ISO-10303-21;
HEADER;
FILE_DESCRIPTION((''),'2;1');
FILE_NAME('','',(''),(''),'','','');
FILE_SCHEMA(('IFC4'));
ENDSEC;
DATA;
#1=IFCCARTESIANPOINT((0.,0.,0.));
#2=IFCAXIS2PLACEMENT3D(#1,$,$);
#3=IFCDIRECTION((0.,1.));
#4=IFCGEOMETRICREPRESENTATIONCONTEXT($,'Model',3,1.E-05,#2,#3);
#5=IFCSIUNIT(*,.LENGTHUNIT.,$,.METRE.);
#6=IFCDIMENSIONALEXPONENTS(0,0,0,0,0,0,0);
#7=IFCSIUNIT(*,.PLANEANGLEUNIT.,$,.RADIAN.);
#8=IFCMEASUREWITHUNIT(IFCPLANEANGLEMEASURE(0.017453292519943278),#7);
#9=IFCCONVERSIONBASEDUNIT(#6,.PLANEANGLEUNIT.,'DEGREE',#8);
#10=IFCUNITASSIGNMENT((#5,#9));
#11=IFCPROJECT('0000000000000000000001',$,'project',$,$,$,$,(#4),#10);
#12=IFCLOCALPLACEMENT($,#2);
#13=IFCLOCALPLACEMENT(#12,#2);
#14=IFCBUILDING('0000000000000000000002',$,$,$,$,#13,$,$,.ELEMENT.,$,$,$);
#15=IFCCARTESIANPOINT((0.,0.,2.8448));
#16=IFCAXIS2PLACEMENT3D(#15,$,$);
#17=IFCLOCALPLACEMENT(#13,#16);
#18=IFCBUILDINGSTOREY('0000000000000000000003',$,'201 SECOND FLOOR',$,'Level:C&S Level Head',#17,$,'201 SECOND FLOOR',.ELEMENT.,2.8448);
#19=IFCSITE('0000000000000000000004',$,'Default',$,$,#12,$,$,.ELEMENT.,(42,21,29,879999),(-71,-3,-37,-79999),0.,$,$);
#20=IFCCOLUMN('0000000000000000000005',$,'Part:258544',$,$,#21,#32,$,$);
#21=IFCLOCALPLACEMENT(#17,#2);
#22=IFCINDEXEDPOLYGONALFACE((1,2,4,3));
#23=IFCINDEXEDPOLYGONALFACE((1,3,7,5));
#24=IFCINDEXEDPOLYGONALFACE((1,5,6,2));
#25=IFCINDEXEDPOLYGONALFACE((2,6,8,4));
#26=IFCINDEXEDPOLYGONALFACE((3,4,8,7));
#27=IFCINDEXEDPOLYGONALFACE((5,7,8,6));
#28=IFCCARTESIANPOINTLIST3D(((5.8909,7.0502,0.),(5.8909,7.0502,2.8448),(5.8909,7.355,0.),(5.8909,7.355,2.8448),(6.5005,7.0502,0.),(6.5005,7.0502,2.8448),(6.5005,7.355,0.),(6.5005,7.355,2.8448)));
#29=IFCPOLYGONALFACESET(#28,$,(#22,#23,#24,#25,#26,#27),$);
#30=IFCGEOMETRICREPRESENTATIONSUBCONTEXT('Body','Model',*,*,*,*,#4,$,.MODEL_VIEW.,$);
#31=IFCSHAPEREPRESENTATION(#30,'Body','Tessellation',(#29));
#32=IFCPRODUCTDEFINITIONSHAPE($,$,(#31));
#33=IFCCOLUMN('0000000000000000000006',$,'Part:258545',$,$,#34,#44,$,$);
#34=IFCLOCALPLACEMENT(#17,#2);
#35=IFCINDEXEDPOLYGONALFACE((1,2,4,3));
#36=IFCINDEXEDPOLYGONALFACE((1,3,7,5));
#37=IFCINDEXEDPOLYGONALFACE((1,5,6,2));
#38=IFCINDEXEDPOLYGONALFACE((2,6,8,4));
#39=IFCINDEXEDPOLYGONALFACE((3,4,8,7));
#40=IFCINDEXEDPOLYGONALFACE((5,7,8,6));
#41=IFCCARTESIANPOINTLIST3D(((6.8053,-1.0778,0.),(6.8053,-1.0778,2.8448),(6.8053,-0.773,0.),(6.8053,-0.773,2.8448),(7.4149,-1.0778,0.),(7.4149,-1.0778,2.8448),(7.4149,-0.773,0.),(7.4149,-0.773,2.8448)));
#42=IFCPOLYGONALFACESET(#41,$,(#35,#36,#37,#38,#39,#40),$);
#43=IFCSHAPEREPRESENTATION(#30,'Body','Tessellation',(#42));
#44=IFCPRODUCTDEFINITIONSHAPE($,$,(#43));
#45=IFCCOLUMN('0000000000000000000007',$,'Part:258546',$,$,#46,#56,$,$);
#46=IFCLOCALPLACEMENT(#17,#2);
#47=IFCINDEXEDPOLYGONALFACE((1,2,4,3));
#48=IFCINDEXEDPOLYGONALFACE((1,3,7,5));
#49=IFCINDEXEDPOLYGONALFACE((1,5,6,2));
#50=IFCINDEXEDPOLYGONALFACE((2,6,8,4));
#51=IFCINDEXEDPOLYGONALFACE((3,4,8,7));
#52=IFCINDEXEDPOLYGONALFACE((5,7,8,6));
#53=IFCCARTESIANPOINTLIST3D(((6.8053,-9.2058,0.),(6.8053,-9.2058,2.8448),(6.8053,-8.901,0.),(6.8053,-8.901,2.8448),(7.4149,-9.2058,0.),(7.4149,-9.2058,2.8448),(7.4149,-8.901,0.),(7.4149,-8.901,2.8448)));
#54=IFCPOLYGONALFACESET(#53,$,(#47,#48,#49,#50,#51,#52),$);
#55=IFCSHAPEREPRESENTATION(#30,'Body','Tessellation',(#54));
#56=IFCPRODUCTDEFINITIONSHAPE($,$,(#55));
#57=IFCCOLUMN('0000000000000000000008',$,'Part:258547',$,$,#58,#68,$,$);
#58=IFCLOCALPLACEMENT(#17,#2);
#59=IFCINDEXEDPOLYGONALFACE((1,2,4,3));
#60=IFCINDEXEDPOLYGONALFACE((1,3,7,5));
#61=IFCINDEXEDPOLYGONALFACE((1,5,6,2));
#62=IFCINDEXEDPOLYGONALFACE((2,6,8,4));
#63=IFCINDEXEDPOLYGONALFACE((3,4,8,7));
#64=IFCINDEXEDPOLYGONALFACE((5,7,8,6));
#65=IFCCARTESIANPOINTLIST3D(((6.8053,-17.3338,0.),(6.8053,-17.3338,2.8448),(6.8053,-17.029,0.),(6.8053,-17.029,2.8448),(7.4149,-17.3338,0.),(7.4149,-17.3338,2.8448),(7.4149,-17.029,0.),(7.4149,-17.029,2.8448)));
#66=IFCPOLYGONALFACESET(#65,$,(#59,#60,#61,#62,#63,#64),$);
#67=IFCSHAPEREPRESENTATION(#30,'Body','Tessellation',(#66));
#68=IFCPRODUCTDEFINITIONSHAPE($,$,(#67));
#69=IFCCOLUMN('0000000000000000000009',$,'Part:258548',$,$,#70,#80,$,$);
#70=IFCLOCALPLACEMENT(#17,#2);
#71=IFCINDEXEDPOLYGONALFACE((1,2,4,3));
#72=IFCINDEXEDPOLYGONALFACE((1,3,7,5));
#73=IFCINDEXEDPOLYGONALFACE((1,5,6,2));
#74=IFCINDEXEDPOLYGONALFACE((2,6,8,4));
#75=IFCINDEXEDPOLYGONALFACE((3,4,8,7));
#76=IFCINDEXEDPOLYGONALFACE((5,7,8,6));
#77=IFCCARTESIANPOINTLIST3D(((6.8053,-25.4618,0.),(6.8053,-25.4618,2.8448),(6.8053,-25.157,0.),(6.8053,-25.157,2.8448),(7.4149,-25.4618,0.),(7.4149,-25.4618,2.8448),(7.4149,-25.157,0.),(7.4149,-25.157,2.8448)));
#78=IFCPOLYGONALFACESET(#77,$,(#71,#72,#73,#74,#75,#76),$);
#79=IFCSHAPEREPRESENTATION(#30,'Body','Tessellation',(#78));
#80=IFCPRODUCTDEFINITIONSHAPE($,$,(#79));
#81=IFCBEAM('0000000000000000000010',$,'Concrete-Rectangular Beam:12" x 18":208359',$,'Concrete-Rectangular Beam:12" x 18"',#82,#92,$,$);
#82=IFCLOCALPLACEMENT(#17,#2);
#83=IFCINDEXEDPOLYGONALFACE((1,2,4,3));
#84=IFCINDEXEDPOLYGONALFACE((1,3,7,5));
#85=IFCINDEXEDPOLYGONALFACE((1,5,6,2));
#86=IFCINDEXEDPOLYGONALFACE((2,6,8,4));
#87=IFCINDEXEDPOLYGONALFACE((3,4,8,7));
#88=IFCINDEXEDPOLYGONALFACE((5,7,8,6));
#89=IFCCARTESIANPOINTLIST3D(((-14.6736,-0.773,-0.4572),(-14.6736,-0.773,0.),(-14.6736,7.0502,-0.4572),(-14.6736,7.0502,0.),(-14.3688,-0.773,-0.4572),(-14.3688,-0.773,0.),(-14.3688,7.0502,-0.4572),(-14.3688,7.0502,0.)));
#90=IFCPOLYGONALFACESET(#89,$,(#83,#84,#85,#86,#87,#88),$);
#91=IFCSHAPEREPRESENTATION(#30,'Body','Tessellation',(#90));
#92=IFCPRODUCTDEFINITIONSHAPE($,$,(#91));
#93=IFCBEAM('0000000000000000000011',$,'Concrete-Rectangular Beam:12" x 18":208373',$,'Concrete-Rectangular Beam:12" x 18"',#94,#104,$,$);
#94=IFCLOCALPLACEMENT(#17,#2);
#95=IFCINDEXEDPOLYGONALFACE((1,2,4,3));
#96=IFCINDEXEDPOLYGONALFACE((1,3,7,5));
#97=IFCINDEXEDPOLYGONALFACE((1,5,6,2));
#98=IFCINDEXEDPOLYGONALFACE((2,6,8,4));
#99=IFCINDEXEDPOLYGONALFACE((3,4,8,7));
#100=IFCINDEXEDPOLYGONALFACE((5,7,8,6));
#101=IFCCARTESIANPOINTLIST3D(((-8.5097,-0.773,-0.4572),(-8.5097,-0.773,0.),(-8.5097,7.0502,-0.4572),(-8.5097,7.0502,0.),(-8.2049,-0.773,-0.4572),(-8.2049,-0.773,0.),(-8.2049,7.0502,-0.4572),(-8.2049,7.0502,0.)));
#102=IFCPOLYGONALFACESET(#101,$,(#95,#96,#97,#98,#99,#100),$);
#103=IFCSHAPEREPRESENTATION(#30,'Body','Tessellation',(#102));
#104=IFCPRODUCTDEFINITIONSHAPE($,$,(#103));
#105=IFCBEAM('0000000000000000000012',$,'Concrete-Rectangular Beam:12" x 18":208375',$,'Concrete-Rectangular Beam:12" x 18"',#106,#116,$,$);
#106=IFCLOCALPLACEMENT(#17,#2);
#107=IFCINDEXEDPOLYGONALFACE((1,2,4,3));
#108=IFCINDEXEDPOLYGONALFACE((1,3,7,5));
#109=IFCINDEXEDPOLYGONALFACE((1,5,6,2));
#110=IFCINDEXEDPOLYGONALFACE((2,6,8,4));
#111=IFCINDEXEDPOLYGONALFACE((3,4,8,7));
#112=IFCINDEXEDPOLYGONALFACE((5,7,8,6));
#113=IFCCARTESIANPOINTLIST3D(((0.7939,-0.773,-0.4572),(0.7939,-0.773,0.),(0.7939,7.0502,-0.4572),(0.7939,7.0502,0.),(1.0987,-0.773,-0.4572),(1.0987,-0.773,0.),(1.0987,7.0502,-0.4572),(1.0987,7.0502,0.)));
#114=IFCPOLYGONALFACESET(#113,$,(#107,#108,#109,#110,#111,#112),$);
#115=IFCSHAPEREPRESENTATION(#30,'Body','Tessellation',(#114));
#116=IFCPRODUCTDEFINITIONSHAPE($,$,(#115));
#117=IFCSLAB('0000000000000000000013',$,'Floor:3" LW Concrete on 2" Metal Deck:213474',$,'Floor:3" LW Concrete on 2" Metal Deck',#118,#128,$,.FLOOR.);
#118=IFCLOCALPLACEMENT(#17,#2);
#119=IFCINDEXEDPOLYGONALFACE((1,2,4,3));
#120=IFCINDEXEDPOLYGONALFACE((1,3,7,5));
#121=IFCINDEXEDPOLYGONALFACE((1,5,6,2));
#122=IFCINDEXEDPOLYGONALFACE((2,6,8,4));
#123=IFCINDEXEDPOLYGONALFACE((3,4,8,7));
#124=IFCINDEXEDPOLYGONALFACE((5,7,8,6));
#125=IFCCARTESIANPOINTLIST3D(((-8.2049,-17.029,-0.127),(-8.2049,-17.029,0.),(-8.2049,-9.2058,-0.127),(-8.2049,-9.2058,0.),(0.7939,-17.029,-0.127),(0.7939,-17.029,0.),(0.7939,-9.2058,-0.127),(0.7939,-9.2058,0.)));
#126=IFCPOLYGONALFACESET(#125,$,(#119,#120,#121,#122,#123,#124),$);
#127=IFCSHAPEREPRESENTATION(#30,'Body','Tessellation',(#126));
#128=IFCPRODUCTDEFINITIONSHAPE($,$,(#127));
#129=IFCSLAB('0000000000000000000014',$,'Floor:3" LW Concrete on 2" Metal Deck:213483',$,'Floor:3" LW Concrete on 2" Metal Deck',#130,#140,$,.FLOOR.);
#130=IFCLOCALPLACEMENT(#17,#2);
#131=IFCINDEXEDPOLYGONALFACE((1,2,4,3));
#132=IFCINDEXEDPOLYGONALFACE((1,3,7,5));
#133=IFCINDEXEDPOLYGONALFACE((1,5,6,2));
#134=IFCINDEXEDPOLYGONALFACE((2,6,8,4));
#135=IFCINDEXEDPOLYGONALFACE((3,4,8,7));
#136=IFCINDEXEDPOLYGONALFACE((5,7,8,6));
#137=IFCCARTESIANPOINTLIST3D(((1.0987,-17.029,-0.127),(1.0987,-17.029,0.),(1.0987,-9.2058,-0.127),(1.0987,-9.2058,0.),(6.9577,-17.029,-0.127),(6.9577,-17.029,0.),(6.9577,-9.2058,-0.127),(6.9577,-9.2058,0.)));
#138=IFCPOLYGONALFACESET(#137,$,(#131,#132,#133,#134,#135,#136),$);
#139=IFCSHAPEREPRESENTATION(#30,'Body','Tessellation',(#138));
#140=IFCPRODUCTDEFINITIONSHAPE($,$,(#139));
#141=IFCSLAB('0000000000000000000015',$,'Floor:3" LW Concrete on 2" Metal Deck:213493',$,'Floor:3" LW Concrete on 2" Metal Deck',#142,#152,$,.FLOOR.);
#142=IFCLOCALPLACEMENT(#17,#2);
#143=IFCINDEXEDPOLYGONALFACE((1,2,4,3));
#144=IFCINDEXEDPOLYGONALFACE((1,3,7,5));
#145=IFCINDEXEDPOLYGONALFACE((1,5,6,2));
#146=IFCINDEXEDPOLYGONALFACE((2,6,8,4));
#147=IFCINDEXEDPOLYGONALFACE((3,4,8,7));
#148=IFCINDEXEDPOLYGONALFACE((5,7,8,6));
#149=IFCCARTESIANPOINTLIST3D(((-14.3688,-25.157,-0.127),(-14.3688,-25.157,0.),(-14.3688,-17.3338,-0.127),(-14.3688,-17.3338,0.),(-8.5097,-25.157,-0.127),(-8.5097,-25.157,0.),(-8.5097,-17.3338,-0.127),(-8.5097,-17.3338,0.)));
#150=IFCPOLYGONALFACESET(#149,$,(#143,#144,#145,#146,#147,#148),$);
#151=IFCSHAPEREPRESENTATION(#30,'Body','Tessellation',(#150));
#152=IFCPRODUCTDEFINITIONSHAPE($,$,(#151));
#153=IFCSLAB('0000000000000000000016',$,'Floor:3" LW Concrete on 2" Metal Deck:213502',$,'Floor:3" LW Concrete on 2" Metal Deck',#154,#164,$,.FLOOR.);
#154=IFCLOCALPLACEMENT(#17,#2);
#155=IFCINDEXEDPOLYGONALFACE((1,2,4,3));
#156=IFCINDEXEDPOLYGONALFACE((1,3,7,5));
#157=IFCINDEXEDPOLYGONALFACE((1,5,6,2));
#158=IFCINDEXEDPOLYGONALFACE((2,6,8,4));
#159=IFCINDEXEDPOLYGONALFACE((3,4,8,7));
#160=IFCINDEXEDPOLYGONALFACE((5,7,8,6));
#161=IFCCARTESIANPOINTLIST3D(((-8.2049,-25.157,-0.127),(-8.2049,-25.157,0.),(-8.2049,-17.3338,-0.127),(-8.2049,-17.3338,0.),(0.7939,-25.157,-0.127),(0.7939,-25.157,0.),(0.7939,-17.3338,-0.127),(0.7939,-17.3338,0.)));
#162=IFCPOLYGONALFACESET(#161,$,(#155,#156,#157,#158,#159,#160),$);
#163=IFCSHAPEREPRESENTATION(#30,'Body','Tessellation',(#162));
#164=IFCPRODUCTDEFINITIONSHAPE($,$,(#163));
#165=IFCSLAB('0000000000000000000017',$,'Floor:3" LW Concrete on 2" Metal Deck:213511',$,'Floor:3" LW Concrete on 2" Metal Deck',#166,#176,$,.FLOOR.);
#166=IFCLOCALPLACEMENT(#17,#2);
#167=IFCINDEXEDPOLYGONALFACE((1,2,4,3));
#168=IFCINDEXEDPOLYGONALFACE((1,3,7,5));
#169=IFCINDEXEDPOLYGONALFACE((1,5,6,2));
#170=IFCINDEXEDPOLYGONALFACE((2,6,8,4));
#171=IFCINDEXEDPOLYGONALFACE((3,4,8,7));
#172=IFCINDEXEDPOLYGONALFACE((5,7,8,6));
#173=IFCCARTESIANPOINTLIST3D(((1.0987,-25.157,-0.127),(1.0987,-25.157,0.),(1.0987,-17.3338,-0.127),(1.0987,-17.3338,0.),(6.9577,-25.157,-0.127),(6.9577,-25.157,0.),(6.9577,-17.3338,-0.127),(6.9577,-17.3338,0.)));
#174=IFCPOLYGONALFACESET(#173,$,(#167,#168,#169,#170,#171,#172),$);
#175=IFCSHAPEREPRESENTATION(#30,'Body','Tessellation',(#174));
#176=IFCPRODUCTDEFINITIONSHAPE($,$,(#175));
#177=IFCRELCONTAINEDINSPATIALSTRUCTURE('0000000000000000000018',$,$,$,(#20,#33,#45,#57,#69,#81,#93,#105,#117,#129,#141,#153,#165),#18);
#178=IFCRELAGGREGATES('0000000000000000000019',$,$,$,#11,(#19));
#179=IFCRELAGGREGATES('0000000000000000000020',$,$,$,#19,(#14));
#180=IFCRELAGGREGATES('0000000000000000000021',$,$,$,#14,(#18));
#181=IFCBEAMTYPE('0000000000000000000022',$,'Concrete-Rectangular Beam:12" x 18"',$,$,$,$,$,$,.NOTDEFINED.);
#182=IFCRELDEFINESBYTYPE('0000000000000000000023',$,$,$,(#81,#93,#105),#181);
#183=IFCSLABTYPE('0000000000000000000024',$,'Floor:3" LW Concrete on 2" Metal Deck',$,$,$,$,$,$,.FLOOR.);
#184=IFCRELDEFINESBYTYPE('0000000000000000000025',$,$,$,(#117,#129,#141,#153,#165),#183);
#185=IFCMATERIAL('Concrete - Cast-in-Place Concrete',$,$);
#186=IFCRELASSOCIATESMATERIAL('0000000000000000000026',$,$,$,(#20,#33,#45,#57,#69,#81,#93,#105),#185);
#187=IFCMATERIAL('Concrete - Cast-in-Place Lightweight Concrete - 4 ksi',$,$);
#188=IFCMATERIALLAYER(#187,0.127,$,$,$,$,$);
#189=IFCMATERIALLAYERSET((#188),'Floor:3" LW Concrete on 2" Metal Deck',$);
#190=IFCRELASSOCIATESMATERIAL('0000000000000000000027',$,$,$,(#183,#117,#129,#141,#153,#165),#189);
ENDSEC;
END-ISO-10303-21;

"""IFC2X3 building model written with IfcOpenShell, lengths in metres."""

from ifc_helpers import new_model, entity, si_unit, converted_unit, direction, frame, frame_2d, origin, origin_2d_with_axis, place, context, subcontext, project, spatial, rectangle, extrude, material, layer, layer_set, layer_usage, type_object, element, save


model = new_model("IFC2X3")

# Units and contexts
model_context = context("Model", 3, precision=1e-05, world=origin(), true_north=direction((0.0, 1.0)))
body_context = subcontext(model_context, "Body", "Model", "MODEL_VIEW")
ifc_project = project(units=[si_unit("LENGTHUNIT", "METRE"), converted_unit("PLANEANGLEUNIT", "DEGREE", entity("IfcPlaneAngleMeasure", 0.017453292519943278), si_unit("PLANEANGLEUNIT", "RADIAN"), dimensions=[0, 0, 0, 0, 0, 0, 0])], contexts=[model_context])

# Site, building, storey
site_placement = place(None, origin())
site = spatial("IfcSite", under=ifc_project, at=site_placement, Name="Default", CompositionType="ELEMENT", RefLatitude=(42, 21, 29, 879999), RefLongitude=(-71, -3, -37, -79999), RefElevation=0.0)
building_placement = place(site_placement, origin())
building = spatial("IfcBuilding", under=site, at=building_placement, CompositionType="ELEMENT")
storey_placement = place(building_placement, frame((0.0, 0.0, 2.8448)))
storey = spatial("IfcBuildingStorey", under=building, at=storey_placement, Name="201 SECOND FLOOR", ObjectType="Level:C&S Level Head", LongName="201 SECOND FLOOR", CompositionType="ELEMENT", Elevation=2.8448)

# Columns
ifc_material_1 = material(Name="Concrete - Cast-in-Place Concrete")
column_1_placement = place(storey_placement, origin())
element("IfcColumn", 1, at=column_1_placement, inside=storey, material=ifc_material_1, Name="Part:258544", context=body_context, shape_type="SweptSolid", body=[
    extrude(rectangle(XDim=2.8448, YDim=0.3048, at=frame_2d((0.0, 0.0), x_axis=(1.0, 0.0))), frame((5.8909, 7.2026, 1.4224), z_axis=(1.0, 0.0, 0.0), x_axis=(0.0, 0.0, -1.0)), (0.0, 0.0, 1.0), 0.6096),
])
column_2_placement = place(storey_placement, origin())
element("IfcColumn", 2, at=column_2_placement, inside=storey, material=ifc_material_1, Name="Part:258545", context=body_context, shape_type="SweptSolid", body=[
    extrude(rectangle(XDim=2.8448, YDim=0.3048, at=frame_2d((0.0, 0.0), x_axis=(1.0, 0.0))), frame((6.8053, -0.9254, 1.4224), z_axis=(1.0, 0.0, 0.0), x_axis=(0.0, 0.0, -1.0)), (0.0, 0.0, 1.0), 0.6096),
])
column_3_placement = place(storey_placement, origin())
element("IfcColumn", 3, at=column_3_placement, inside=storey, material=ifc_material_1, Name="Part:258546", context=body_context, shape_type="SweptSolid", body=[
    extrude(rectangle(XDim=2.8448, YDim=0.3048, at=frame_2d((0.0, 0.0), x_axis=(1.0, 0.0))), frame((6.8053, -9.0534, 1.4224), z_axis=(1.0, 0.0, 0.0), x_axis=(0.0, 0.0, -1.0)), (0.0, 0.0, 1.0), 0.6096),
])
column_4_placement = place(storey_placement, origin())
element("IfcColumn", 4, at=column_4_placement, inside=storey, material=ifc_material_1, Name="Part:258547", context=body_context, shape_type="SweptSolid", body=[
    extrude(rectangle(XDim=2.8448, YDim=0.3048, at=frame_2d((0.0, 0.0), x_axis=(1.0, 0.0))), frame((6.8053, -17.1814, 1.4224), z_axis=(1.0, 0.0, 0.0), x_axis=(0.0, 0.0, -1.0)), (0.0, 0.0, 1.0), 0.6096),
])
column_5_placement = place(storey_placement, origin())
element("IfcColumn", 5, at=column_5_placement, inside=storey, material=ifc_material_1, Name="Part:258548", context=body_context, shape_type="SweptSolid", body=[
    extrude(rectangle(XDim=2.8448, YDim=0.3048, at=frame_2d((0.0, 0.0), x_axis=(1.0, 0.0))), frame((6.8053, -25.3094, 1.4224), z_axis=(1.0, 0.0, 0.0), x_axis=(0.0, 0.0, -1.0)), (0.0, 0.0, 1.0), 0.6096),
])

# Beams
beam_type = type_object("IfcBeamType", Name="Concrete-Rectangular Beam:12\" x 18\"", PredefinedType="NOTDEFINED")
beam_1_placement = place(storey_placement, frame((-14.5212, 7.0502, 0.0), z_axis=(0.0, 0.0, 1.0), x_axis=(0.0, -1.0, 0.0)))
element("IfcBeam", 6, at=beam_1_placement, inside=storey, type_object=beam_type, material=ifc_material_1, Name="Concrete-Rectangular Beam:12\" x 18\":208359", ObjectType="Concrete-Rectangular Beam:12\" x 18\"", context=body_context, shape_type="SweptSolid", body=[
    extrude(rectangle(XDim=0.4572, YDim=0.3048, at=origin_2d_with_axis()), frame((0.0, 0.0, -0.2286), z_axis=(1.0, 0.0, 0.0), x_axis=(0.0, 0.0, -1.0)), (0.0, 0.0, 1.0), 7.8232),
])
beam_2_placement = place(storey_placement, frame((-8.3573, 7.0502, 0.0), z_axis=(0.0, 0.0, 1.0), x_axis=(0.0, -1.0, 0.0)))
element("IfcBeam", 7, at=beam_2_placement, inside=storey, type_object=beam_type, material=ifc_material_1, Name="Concrete-Rectangular Beam:12\" x 18\":208373", ObjectType="Concrete-Rectangular Beam:12\" x 18\"", context=body_context, shape_type="SweptSolid", body=[
    extrude(rectangle(XDim=0.4572, YDim=0.3048, at=frame_2d((0.0, 0.0), x_axis=(1.0, 0.0))), frame((0.0, 0.0, -0.2286), z_axis=(1.0, 0.0, 0.0), x_axis=(0.0, 0.0, -1.0)), (0.0, 0.0, 1.0), 7.8232),
])
beam_3_placement = place(storey_placement, frame((0.9463, 7.0502, 0.0), z_axis=(0.0, 0.0, 1.0), x_axis=(0.0, -1.0, 0.0)))
element("IfcBeam", 8, at=beam_3_placement, inside=storey, type_object=beam_type, material=ifc_material_1, Name="Concrete-Rectangular Beam:12\" x 18\":208375", ObjectType="Concrete-Rectangular Beam:12\" x 18\"", context=body_context, shape_type="SweptSolid", body=[
    extrude(rectangle(XDim=0.4572, YDim=0.3048, at=origin_2d_with_axis()), frame((0.0, 0.0, -0.2286), z_axis=(1.0, 0.0, 0.0), x_axis=(0.0, 0.0, -1.0)), (0.0, 0.0, 1.0), 7.8232),
])

# Slabs
ifc_material_2 = material(Name="Concrete - Cast-in-Place Lightweight Concrete - 4 ksi")
ifc_layer = layer(ifc_material_2, 0.127)
ifc_layer_set = layer_set([ifc_layer], Name="Floor:3\" LW Concrete on 2\" Metal Deck")
ifc_layer_usage_1 = layer_usage(ifc_layer_set, "AXIS3", "POSITIVE", 0.0)
slab_type = type_object("IfcSlabType", Name="Floor:3\" LW Concrete on 2\" Metal Deck", PredefinedType="FLOOR", material=ifc_layer_set)
slab_1_placement = place(storey_placement, origin())
element("IfcSlab", 9, at=slab_1_placement, inside=storey, type_object=slab_type, material=ifc_layer_usage_1, Name="Floor:3\" LW Concrete on 2\" Metal Deck:213474", ObjectType="Floor:3\" LW Concrete on 2\" Metal Deck", PredefinedType="FLOOR", context=body_context, shape_type="SweptSolid", body=[
    extrude(rectangle(XDim=7.8232, YDim=8.9988, at=frame_2d((0.0, 0.0), x_axis=(1.0, 0.0))), frame((-3.7055, -13.1174, 0.0), z_axis=(0.0, 0.0, -1.0), x_axis=(0.0, 1.0, 0.0)), (0.0, 0.0, 1.0), 0.127),
])
ifc_layer_usage_2 = layer_usage(ifc_layer_set, "AXIS3", "POSITIVE", 0.0)
slab_2_placement = place(storey_placement, origin())
element("IfcSlab", 10, at=slab_2_placement, inside=storey, type_object=slab_type, material=ifc_layer_usage_2, Name="Floor:3\" LW Concrete on 2\" Metal Deck:213483", ObjectType="Floor:3\" LW Concrete on 2\" Metal Deck", PredefinedType="FLOOR", context=body_context, shape_type="SweptSolid", body=[
    extrude(rectangle(XDim=7.8232, YDim=5.859, at=frame_2d((0.0, 0.0), x_axis=(1.0, 0.0))), frame((4.0282, -13.1174, 0.0), z_axis=(0.0, 0.0, -1.0), x_axis=(0.0, 1.0, 0.0)), (0.0, 0.0, 1.0), 0.127),
])
ifc_layer_usage_3 = layer_usage(ifc_layer_set, "AXIS3", "POSITIVE", 0.0)
slab_3_placement = place(storey_placement, origin())
element("IfcSlab", 11, at=slab_3_placement, inside=storey, type_object=slab_type, material=ifc_layer_usage_3, Name="Floor:3\" LW Concrete on 2\" Metal Deck:213493", ObjectType="Floor:3\" LW Concrete on 2\" Metal Deck", PredefinedType="FLOOR", context=body_context, shape_type="SweptSolid", body=[
    extrude(rectangle(XDim=7.8232, YDim=5.859, at=frame_2d((0.0, 0.0), x_axis=(1.0, 0.0))), frame((-11.4393, -21.2454, 0.0), z_axis=(0.0, 0.0, -1.0), x_axis=(0.0, 1.0, 0.0)), (0.0, 0.0, 1.0), 0.127),
])
ifc_layer_usage_4 = layer_usage(ifc_layer_set, "AXIS3", "POSITIVE", 0.0)
slab_4_placement = place(storey_placement, origin())
element("IfcSlab", 12, at=slab_4_placement, inside=storey, type_object=slab_type, material=ifc_layer_usage_4, Name="Floor:3\" LW Concrete on 2\" Metal Deck:213502", ObjectType="Floor:3\" LW Concrete on 2\" Metal Deck", PredefinedType="FLOOR", context=body_context, shape_type="SweptSolid", body=[
    extrude(rectangle(XDim=7.8232, YDim=8.9988, at=frame_2d((0.0, 0.0), x_axis=(1.0, 0.0))), frame((-3.7055, -21.2454, 0.0), z_axis=(0.0, 0.0, -1.0), x_axis=(0.0, 1.0, 0.0)), (0.0, 0.0, 1.0), 0.127),
])
ifc_layer_usage_5 = layer_usage(ifc_layer_set, "AXIS3", "POSITIVE", 0.0)
slab_5_placement = place(storey_placement, origin())
element("IfcSlab", 13, at=slab_5_placement, inside=storey, type_object=slab_type, material=ifc_layer_usage_5, Name="Floor:3\" LW Concrete on 2\" Metal Deck:213511", ObjectType="Floor:3\" LW Concrete on 2\" Metal Deck", PredefinedType="FLOOR", context=body_context, shape_type="SweptSolid", body=[
    extrude(rectangle(XDim=7.8232, YDim=5.859, at=frame_2d((0.0, 0.0), x_axis=(1.0, 0.0))), frame((4.0282, -21.2454, 0.0), z_axis=(0.0, 0.0, -1.0), x_axis=(0.0, 1.0, 0.0)), (0.0, 0.0, 1.0), 0.127),
])

save(model, "model.ifc")
